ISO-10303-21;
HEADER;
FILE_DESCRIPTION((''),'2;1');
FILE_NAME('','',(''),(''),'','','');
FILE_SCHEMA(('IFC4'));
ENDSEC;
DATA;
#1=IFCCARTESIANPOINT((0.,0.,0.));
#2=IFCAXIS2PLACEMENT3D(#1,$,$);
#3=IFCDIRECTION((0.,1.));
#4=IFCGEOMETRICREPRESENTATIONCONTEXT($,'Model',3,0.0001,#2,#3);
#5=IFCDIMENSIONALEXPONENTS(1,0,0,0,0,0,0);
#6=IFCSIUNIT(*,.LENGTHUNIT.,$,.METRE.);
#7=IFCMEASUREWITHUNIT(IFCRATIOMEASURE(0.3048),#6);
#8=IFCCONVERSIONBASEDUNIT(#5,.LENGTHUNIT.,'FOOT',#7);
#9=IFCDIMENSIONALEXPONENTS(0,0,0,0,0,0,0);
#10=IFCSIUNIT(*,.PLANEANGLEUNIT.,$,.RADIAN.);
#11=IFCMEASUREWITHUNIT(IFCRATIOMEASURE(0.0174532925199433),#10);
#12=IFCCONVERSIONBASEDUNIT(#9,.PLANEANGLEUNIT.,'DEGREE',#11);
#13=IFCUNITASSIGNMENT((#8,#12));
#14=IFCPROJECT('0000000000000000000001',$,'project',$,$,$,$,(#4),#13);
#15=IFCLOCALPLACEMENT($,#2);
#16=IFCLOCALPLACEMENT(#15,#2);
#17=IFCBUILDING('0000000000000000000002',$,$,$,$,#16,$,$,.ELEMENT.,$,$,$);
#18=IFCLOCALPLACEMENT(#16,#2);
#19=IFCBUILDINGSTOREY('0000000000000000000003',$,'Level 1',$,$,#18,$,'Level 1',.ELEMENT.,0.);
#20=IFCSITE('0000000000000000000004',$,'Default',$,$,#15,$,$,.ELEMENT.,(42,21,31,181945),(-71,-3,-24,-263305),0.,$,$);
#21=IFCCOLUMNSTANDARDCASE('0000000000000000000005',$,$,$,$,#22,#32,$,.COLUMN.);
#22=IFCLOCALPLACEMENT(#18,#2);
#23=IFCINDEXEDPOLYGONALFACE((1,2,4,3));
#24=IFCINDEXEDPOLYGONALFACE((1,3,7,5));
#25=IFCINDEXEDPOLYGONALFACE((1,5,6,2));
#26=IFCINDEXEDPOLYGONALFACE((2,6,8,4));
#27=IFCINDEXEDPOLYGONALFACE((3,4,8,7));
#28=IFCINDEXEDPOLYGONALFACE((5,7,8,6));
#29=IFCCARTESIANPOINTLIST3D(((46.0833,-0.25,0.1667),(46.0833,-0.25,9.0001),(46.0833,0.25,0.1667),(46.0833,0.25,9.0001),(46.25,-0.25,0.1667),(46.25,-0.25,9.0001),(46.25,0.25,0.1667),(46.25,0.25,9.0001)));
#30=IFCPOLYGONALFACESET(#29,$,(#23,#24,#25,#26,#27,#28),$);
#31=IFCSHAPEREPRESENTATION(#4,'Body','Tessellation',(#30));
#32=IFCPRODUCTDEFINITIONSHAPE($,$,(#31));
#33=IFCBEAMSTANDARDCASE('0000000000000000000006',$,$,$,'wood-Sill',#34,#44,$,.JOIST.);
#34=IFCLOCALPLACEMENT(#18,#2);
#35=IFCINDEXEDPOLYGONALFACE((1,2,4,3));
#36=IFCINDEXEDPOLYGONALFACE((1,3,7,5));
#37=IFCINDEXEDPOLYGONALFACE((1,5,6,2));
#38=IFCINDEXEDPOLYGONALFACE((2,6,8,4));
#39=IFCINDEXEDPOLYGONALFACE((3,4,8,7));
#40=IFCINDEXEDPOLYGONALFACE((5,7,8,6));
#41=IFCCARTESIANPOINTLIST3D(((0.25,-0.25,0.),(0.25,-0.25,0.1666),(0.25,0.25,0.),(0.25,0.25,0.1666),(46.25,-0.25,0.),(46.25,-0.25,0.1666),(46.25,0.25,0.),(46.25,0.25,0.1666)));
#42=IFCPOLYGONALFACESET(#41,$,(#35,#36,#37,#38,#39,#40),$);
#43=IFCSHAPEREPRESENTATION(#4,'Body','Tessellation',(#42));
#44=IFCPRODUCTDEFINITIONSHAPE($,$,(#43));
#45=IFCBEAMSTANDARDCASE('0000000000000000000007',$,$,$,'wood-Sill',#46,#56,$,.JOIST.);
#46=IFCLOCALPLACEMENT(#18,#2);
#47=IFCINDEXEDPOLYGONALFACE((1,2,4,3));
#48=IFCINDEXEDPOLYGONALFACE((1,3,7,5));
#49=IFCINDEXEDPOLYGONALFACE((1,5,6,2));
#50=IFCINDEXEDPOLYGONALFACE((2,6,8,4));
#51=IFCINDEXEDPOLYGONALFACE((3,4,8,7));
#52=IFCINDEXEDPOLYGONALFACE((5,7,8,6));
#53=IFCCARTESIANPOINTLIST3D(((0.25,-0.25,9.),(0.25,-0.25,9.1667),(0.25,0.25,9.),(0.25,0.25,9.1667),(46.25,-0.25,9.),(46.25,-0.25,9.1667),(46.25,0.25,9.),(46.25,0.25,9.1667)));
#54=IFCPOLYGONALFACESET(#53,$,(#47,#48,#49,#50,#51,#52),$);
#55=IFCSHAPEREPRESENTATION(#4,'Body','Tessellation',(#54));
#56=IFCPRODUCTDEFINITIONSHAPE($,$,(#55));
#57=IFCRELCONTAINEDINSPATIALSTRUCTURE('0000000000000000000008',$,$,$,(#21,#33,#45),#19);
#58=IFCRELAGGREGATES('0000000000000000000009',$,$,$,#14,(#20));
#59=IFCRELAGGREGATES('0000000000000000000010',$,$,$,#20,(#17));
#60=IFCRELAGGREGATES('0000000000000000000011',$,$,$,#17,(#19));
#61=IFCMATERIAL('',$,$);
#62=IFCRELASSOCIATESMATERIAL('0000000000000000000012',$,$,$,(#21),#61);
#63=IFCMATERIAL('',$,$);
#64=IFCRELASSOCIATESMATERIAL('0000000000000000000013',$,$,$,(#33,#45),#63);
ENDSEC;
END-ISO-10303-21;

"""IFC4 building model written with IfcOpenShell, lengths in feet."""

from ifc_helpers import new_model, entity, si_unit, converted_unit, direction, frame, origin, origin_with_axes, place, context, project, spatial, rectangle, extrude, material, element, save


model = new_model("IFC4")

# Units and contexts
model_context = context("Model", 3, precision=0.0001, world=origin(), true_north=direction((0.0, 1.0)))
ifc_project = project(units=[converted_unit("LENGTHUNIT", "FOOT", entity("IfcRatioMeasure", 0.3048), si_unit("LENGTHUNIT", "METRE"), dimensions=[1, 0, 0, 0, 0, 0, 0]), converted_unit("PLANEANGLEUNIT", "DEGREE", entity("IfcRatioMeasure", 0.0174532925199433), si_unit("PLANEANGLEUNIT", "RADIAN"), dimensions=[0, 0, 0, 0, 0, 0, 0])], contexts=[model_context])

# Site, building, storey
site_placement = place(None, origin())
site = spatial("IfcSite", under=ifc_project, at=site_placement, Name="Default", CompositionType="ELEMENT", RefLatitude=(42, 21, 31, 181945), RefLongitude=(-71, -3, -24, -263305), RefElevation=0.0)
building_placement = place(site_placement, origin())
building = spatial("IfcBuilding", under=site, at=building_placement, CompositionType="ELEMENT")
storey_placement = place(building_placement, origin())
storey = spatial("IfcBuildingStorey", under=building, at=storey_placement, Name="Level 1", LongName="Level 1", CompositionType="ELEMENT", Elevation=0.0)

# Column
ifc_material_1 = material(Name="")
placement = place(storey_placement, frame((46.25, 0.0, 0.0), z_axis=(0.0, 0.0, 1.0), x_axis=(-1.0, 0.0, 0.0)))
for number, where, z_axis, x_axis in (
    (1, (0.0833, 0.0, 0.1667), (0.0, 0.0, 1.0), (1.0, 0.0, 0.0)),
):
    element("IfcColumnStandardCase", number, at=place(placement, frame(where, z_axis=z_axis, x_axis=x_axis)), inside=storey, material=ifc_material_1, PredefinedType="COLUMN", context=model_context, shape_type="SweptSolid", body=[
        extrude(rectangle(XDim=0.1667, YDim=0.5), origin(), (0.0, 0.0, 1.0), 8.8334),
    ])

# Beams
ifc_material_2 = material(Name="")
for number, where, z_axis, x_axis in (
    (2, (0.0, 0.0, 0.0833), (1.0, 0.0, 0.0), (0.0, 0.0, 1.0)),
    (3, (0.0, 0.0, 9.0834), (1.0, 0.0, 0.0), (0.0, 0.0, 1.0)),
):
    element("IfcBeamStandardCase", number, at=place(placement, frame(where, z_axis=z_axis, x_axis=x_axis)), inside=storey, material=ifc_material_2, ObjectType="wood-Sill", PredefinedType="JOIST", context=model_context, shape_type="SweptSolid", body=[
        extrude(rectangle(XDim=0.1667, YDim=0.5), origin_with_axes(), (0.0, 0.0, 1.0), 46.0),
    ])

save(model, "model.ifc")
